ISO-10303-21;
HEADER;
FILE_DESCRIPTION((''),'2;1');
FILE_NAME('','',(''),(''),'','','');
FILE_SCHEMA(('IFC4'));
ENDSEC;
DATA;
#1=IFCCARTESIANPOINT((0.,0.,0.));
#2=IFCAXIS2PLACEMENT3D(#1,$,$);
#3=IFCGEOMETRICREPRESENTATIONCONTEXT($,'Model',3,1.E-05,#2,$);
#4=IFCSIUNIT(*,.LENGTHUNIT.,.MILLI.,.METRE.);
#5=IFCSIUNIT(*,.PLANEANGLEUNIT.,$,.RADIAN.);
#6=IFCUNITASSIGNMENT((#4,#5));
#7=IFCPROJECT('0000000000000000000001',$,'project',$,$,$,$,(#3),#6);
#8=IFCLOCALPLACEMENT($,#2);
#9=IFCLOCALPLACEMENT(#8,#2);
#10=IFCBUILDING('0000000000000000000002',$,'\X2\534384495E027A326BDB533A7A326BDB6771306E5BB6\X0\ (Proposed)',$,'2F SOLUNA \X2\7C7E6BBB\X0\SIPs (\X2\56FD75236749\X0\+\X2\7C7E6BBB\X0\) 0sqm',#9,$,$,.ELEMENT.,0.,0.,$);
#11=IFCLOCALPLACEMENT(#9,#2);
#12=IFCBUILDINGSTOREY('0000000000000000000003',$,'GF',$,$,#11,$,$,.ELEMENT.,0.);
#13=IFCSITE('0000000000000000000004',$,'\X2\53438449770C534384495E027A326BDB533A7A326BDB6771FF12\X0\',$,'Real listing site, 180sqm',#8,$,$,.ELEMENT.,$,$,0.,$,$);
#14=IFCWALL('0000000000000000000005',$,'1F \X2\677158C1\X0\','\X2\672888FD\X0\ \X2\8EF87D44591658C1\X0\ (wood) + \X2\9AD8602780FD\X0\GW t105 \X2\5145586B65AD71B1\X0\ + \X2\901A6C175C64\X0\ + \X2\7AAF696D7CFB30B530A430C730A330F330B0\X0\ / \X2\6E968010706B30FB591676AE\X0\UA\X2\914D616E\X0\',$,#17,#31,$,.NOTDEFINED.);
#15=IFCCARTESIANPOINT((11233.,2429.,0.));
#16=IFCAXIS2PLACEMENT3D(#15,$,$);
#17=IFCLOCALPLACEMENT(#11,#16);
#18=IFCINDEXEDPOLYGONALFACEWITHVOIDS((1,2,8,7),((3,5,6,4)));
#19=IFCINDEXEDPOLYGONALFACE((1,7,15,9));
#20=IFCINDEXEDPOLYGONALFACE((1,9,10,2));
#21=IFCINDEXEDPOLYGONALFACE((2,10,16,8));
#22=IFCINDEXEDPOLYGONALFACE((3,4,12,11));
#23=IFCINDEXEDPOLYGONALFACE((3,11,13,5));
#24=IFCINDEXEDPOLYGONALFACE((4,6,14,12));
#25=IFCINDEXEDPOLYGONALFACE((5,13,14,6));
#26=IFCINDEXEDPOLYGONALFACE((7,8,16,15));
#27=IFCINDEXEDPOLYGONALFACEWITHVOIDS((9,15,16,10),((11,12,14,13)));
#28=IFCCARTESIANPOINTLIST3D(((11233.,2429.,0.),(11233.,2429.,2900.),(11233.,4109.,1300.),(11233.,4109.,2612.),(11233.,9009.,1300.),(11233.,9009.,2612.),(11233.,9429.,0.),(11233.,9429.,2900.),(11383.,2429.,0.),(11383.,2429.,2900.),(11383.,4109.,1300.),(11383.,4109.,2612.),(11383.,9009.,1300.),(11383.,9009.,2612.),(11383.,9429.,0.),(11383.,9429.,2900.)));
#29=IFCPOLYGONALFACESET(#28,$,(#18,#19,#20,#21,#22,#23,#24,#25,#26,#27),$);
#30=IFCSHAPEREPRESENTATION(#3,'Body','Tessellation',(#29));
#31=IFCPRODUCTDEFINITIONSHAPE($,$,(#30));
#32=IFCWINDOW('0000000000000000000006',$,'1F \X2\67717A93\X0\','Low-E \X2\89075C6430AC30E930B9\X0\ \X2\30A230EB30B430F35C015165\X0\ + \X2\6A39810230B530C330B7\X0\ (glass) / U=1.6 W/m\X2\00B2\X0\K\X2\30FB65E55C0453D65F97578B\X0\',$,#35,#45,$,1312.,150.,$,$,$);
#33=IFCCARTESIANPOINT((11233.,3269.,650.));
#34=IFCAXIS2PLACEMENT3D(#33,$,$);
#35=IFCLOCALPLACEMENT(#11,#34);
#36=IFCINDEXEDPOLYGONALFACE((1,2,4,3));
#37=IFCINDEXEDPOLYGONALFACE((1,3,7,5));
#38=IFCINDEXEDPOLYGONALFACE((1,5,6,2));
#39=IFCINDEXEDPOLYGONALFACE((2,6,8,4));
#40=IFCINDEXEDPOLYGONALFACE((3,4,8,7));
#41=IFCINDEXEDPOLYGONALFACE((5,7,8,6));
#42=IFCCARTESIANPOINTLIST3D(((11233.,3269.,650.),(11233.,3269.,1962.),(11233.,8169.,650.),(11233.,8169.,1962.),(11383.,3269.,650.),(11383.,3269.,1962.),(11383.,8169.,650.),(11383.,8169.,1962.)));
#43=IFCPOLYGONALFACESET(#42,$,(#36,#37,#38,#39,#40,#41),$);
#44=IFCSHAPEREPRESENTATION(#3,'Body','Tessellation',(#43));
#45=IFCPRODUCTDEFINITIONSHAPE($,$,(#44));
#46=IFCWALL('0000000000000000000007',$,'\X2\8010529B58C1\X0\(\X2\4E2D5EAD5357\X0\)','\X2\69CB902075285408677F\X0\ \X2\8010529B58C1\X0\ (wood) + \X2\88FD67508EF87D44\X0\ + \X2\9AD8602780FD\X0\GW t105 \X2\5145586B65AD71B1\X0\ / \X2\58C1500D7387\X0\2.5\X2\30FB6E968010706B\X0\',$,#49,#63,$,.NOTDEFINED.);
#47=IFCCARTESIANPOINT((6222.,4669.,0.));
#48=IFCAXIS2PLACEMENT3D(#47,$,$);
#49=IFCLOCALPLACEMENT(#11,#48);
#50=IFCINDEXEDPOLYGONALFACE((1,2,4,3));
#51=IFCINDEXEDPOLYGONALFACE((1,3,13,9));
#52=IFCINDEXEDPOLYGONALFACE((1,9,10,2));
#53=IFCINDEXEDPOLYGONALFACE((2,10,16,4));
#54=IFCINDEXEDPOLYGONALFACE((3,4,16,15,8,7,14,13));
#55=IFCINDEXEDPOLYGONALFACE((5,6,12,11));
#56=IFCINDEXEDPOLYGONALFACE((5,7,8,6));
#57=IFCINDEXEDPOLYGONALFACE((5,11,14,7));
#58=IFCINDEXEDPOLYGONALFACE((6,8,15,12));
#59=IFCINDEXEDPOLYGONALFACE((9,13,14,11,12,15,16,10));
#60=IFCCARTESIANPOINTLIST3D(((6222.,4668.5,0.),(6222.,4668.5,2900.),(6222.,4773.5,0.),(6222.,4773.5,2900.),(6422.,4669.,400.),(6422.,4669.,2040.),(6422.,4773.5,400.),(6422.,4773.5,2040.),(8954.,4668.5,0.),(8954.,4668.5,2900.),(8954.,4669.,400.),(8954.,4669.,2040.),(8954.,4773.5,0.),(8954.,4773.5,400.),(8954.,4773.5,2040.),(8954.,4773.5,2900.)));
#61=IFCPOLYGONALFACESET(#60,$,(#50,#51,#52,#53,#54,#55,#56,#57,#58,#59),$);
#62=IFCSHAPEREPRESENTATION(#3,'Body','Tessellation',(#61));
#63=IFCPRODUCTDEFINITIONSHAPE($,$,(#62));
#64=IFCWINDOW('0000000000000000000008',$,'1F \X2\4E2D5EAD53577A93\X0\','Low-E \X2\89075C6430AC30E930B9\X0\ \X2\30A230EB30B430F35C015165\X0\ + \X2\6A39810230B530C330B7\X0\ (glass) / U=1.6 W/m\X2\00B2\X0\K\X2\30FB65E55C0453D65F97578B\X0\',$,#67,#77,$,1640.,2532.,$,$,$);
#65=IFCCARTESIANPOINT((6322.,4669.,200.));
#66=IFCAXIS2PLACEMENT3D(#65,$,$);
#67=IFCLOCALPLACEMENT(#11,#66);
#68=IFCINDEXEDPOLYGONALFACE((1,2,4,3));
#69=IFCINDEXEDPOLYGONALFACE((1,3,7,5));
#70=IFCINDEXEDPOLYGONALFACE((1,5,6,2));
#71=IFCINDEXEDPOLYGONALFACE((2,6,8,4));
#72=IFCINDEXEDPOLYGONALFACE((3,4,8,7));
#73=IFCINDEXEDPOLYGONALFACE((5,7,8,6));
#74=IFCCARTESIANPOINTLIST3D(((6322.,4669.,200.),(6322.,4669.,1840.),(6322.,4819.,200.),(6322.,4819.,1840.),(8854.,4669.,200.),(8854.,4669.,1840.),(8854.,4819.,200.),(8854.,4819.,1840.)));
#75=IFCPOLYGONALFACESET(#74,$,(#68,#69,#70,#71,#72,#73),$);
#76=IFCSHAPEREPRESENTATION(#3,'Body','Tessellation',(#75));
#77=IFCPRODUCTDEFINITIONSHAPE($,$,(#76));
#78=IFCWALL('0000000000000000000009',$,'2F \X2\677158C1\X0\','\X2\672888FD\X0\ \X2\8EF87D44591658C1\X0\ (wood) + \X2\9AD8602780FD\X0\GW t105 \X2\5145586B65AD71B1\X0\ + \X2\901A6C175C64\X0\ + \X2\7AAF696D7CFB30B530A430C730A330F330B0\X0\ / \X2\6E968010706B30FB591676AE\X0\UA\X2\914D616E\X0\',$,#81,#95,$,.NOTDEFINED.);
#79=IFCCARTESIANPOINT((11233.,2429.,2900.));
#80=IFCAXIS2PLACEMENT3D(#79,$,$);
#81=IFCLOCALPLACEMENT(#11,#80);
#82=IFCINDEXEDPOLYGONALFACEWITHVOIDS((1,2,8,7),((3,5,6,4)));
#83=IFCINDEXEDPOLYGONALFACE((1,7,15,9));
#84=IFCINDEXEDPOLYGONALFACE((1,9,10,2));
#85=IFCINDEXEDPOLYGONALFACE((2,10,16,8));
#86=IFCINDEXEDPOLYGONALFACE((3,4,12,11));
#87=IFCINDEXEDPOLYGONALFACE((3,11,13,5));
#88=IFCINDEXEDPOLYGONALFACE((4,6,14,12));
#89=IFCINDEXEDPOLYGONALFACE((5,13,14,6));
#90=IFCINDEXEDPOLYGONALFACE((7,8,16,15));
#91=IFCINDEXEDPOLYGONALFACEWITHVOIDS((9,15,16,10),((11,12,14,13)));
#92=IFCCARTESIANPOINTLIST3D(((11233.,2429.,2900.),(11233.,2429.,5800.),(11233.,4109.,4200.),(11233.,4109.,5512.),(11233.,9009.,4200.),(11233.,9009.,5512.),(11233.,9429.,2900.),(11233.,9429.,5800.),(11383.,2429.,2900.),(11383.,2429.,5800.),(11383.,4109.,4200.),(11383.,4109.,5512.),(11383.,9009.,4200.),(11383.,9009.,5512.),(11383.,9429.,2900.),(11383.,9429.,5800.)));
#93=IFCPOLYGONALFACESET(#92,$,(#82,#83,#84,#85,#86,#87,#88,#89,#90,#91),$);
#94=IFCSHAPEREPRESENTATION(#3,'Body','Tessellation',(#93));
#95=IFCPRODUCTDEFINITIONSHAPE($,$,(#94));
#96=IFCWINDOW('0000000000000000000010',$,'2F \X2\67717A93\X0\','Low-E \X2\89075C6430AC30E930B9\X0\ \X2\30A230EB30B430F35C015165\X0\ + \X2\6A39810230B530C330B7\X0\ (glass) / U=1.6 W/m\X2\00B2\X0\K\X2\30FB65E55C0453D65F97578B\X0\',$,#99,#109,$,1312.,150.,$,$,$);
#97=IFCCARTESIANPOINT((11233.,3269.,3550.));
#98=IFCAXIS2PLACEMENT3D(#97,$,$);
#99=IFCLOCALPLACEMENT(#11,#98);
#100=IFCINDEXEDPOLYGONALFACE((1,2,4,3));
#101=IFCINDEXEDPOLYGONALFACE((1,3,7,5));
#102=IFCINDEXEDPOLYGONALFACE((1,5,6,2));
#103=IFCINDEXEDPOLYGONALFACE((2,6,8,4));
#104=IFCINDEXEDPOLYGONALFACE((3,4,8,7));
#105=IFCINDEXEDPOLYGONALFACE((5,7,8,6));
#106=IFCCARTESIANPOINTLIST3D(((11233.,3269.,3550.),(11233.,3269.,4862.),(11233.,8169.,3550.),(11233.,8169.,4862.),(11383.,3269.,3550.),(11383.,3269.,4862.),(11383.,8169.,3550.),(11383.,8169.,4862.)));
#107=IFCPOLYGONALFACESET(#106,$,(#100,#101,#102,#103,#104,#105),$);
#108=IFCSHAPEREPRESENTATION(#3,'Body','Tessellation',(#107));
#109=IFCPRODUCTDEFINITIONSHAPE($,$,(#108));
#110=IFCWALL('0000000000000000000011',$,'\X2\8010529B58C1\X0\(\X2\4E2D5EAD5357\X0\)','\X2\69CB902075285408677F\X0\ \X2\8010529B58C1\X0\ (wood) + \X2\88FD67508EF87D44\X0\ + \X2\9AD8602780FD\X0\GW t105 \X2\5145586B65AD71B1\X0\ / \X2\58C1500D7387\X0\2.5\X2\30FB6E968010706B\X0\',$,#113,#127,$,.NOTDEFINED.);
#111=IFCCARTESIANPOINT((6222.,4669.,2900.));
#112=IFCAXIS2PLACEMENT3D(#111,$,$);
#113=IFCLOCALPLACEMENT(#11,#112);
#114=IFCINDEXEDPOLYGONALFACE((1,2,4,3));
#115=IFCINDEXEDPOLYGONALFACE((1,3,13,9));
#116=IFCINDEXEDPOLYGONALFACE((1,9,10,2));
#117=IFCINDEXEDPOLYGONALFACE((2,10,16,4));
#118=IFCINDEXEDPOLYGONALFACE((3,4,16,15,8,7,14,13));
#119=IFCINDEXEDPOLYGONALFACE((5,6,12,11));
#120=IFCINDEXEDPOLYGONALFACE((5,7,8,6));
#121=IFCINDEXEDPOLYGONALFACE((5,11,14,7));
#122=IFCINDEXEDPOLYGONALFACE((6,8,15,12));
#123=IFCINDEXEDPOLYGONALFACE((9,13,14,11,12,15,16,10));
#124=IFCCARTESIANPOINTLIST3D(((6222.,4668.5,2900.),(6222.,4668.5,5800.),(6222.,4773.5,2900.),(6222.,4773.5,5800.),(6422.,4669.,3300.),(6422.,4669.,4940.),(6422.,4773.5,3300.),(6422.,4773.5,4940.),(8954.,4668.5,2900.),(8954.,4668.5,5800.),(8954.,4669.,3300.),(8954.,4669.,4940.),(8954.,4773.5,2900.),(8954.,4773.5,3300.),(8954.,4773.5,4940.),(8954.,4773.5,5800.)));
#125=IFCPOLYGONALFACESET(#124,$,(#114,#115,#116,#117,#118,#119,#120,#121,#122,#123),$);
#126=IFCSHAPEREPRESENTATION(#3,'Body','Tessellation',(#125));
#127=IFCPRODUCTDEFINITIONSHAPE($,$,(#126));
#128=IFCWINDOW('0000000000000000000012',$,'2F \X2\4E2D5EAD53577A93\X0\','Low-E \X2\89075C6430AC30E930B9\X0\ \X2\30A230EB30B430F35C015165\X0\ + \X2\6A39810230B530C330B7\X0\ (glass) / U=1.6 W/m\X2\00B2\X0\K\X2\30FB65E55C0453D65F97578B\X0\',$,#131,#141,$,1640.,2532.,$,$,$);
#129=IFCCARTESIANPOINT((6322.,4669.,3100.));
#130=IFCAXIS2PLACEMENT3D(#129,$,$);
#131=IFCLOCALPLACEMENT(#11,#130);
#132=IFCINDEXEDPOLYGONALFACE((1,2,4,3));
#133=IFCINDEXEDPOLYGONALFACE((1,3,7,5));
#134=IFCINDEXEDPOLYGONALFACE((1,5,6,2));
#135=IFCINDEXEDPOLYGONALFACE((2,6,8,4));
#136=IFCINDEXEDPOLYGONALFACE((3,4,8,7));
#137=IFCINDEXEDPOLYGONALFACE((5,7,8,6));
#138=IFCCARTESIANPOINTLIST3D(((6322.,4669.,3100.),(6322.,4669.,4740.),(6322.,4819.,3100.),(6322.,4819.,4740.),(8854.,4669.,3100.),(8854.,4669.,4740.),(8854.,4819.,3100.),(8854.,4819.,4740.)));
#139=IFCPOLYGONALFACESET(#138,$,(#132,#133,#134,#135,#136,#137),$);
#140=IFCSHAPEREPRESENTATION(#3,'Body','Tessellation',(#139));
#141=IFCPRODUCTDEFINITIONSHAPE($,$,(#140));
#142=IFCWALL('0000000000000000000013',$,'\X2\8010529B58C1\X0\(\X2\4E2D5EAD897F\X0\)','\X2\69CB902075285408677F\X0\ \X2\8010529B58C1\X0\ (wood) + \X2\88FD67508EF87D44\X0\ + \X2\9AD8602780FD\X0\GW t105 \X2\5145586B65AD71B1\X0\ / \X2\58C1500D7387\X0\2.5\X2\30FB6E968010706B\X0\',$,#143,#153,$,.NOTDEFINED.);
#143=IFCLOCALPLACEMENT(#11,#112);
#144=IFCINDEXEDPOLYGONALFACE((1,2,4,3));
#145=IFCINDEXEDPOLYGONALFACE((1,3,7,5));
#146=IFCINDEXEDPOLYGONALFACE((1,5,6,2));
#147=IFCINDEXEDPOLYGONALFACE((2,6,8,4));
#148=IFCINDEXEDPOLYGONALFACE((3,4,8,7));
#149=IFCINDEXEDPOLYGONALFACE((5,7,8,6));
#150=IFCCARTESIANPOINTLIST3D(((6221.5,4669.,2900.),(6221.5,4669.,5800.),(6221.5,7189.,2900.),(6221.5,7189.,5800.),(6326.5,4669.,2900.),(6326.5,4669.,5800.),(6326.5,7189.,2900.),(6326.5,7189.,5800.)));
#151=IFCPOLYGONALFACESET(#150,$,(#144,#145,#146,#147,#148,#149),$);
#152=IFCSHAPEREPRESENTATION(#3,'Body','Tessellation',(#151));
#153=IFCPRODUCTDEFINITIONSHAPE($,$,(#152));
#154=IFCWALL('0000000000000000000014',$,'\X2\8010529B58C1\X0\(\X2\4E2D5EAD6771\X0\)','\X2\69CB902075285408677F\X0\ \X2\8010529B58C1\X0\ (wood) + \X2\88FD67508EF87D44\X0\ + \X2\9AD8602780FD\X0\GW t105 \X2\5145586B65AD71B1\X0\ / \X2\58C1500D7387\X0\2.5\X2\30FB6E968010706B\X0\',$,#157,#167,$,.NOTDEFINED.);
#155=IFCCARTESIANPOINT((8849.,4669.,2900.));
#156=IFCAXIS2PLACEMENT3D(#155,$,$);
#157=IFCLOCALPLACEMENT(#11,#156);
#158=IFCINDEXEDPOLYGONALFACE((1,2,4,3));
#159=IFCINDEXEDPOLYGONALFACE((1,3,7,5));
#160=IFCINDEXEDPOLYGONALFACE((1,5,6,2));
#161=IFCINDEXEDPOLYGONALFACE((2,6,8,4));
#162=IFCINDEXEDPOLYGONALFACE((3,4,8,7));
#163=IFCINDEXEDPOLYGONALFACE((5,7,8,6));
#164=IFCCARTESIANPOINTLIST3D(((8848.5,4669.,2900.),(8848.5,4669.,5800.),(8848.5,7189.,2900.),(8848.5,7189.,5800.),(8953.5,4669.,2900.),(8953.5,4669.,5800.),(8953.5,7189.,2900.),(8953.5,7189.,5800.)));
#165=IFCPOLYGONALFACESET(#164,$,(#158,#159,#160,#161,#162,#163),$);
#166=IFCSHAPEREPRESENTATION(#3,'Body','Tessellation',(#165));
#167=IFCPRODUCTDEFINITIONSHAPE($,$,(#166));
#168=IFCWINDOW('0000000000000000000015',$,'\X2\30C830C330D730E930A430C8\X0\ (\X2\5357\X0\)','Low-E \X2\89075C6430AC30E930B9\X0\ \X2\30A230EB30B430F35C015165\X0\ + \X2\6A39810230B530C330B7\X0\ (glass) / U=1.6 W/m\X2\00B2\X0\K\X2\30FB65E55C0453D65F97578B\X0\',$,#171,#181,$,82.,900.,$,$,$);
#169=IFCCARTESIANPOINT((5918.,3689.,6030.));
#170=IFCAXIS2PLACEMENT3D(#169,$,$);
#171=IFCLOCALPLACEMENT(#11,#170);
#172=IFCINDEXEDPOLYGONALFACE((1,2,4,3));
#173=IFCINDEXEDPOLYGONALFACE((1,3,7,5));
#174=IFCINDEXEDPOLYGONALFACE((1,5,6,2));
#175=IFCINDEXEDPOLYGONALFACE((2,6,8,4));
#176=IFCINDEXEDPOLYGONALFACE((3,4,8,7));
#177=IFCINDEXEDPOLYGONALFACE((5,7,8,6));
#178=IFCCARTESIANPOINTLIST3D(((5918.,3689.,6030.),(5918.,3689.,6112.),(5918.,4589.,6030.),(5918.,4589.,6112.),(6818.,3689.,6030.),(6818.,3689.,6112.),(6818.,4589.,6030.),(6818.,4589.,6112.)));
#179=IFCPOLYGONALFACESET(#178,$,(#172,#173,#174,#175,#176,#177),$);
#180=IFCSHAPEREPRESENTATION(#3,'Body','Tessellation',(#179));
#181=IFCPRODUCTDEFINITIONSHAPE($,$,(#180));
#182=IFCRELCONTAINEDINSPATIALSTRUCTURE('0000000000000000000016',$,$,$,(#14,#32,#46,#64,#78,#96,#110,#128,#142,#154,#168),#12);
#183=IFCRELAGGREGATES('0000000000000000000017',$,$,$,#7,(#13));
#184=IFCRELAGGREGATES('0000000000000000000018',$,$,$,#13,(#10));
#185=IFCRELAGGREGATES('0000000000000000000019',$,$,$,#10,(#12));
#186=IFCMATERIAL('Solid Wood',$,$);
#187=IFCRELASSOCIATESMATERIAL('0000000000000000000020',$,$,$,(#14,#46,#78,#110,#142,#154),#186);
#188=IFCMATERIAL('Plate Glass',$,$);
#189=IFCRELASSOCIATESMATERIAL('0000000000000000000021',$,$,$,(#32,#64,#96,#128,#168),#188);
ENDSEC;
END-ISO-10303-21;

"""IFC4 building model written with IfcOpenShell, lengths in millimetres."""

from ifc_helpers import new_model, si_unit, frame, frame_2d, origin, place, context, project, spatial, rectangle, extrude, material, element, fill, save


model = new_model("IFC4")

# Units and contexts
model_context = context("Model", 3, precision=1e-05, world=origin())
ifc_project = project(units=[si_unit("LENGTHUNIT", "METRE", prefix="MILLI"), si_unit("PLANEANGLEUNIT", "RADIAN")], contexts=[model_context])

# Site, building, storey
site_placement = place(None, origin())
site = spatial("IfcSite", under=ifc_project, at=site_placement, Name="千葉県千葉市稲毛区稲毛東２", ObjectType="Real listing site, 180sqm", CompositionType="ELEMENT", RefElevation=0.0)
building_placement = place(site_placement, origin())
building = spatial("IfcBuilding", under=site, at=building_placement, Name="千葉市稲毛区稲毛東の家 (Proposed)", ObjectType="2F SOLUNA 籾殻SIPs (国産杉+籾殻) 0sqm", CompositionType="ELEMENT", ElevationOfRefHeight=0.0, ElevationOfTerrain=0.0)
storey_placement = place(building_placement, origin())
storey = spatial("IfcBuildingStorey", under=building, at=storey_placement, Name="GF", CompositionType="ELEMENT", Elevation=0.0)

# Shared definitions
ifc_material_1 = material(Name="Solid Wood")

# Walls, openings, windows
wall_1_placement = place(storey_placement, frame((11233.0, 2429.0, 0.0)))
wall_1 = element("IfcWall", 1, at=wall_1_placement, inside=storey, material=ifc_material_1, Name="1F 東壁", Description="木製 軸組外壁 (wood) + 高性能GW t105 充填断熱 + 通気層 + 窯業系サイディング / 準耐火・外皮UA配慮", PredefinedType="NOTDEFINED", context=model_context, shape_type="SweptSolid", body=[
    extrude(rectangle(XDim=150.0, YDim=7000.0, at=frame_2d((75.0, 3500.0))), frame((11233.0, 2429.0, 0.0)), (0.0, 0.0, 1.0), 2900.0),
])
opening_1_placement = place(storey_placement, frame((11233.0, 3269.0, 650.0)))
opening_1 = element("IfcOpeningElement", 2, at=opening_1_placement, cuts=wall_1, PredefinedType="NOTDEFINED", context=model_context, shape_type="SweptSolid", body=[
    extrude(rectangle(XDim=150.0, YDim=4900.0, at=frame_2d((75.0, 2450.0))), frame((11233.0, 3269.0, 650.0)), (0.0, 0.0, 1.0), 1312.0),
])
ifc_material_2 = material(Name="Plate Glass")
window_1_placement = place(storey_placement, frame((11233.0, 3269.0, 650.0)))
window_1 = element("IfcWindow", 3, at=window_1_placement, inside=storey, material=ifc_material_2, Name="1F 東窓", Description="Low-E 複層ガラス アルゴン封入 + 樹脂サッシ (glass) / U=1.6 W/m²K・日射取得型", OverallHeight=1312.0, OverallWidth=150.0, context=model_context, shape_type="SweptSolid", body=[
    extrude(rectangle(XDim=150.0, YDim=4900.0, at=frame_2d((75.0, 2450.0))), frame((11233.0, 3269.0, 650.0)), (0.0, 0.0, 1.0), 1312.0),
])
fill(opening_1, window_1)
wall_2_placement = place(storey_placement, frame((6222.0, 4669.0, 0.0)))
wall_2 = element("IfcWall", 4, at=wall_2_placement, inside=storey, material=ifc_material_1, Name="耐力壁(中庭南)", Description="構造用合板 耐力壁 (wood) + 製材軸組 + 高性能GW t105 充填断熱 / 壁倍率2.5・準耐火", PredefinedType="NOTDEFINED", context=model_context, shape_type="SweptSolid", body=[
    extrude(rectangle(XDim=2732.0, YDim=105.0, at=frame_2d((1366.0, 52.0))), frame((6222.0, 4669.0, 0.0)), (0.0, 0.0, 1.0), 2900.0),
])
opening_2_placement = place(storey_placement, frame((6322.0, 4669.0, 200.0)))
opening_2 = element("IfcOpeningElement", 5, at=opening_2_placement, cuts=wall_2, PredefinedType="NOTDEFINED", context=model_context, shape_type="SweptSolid", body=[
    extrude(rectangle(XDim=2532.0, YDim=150.0, at=frame_2d((1266.0, 75.0))), frame((6322.0, 4669.0, 200.0)), (0.0, 0.0, 1.0), 1640.0),
])
window_2_placement = place(storey_placement, frame((6322.0, 4669.0, 200.0)))
window_2 = element("IfcWindow", 6, at=window_2_placement, inside=storey, material=ifc_material_2, Name="1F 中庭南窓", Description="Low-E 複層ガラス アルゴン封入 + 樹脂サッシ (glass) / U=1.6 W/m²K・日射取得型", OverallHeight=1640.0, OverallWidth=2532.0, context=model_context, shape_type="SweptSolid", body=[
    extrude(rectangle(XDim=2532.0, YDim=150.0, at=frame_2d((1266.0, 75.0))), frame((6322.0, 4669.0, 200.0)), (0.0, 0.0, 1.0), 1640.0),
])
fill(opening_2, window_2)

# Walls, openings, windows
wall_3_placement = place(storey_placement, frame((11233.0, 2429.0, 2900.0)))
wall_3 = element("IfcWall", 7, at=wall_3_placement, inside=storey, material=ifc_material_1, Name="2F 東壁", Description="木製 軸組外壁 (wood) + 高性能GW t105 充填断熱 + 通気層 + 窯業系サイディング / 準耐火・外皮UA配慮", PredefinedType="NOTDEFINED", context=model_context, shape_type="SweptSolid", body=[
    extrude(rectangle(XDim=150.0, YDim=7000.0, at=frame_2d((75.0, 3500.0))), frame((11233.0, 2429.0, 2900.0)), (0.0, 0.0, 1.0), 2900.0),
])
opening_3_placement = place(storey_placement, frame((11233.0, 3269.0, 3550.0)))
opening_3 = element("IfcOpeningElement", 8, at=opening_3_placement, cuts=wall_3, PredefinedType="NOTDEFINED", context=model_context, shape_type="SweptSolid", body=[
    extrude(rectangle(XDim=150.0, YDim=4900.0, at=frame_2d((75.0, 2450.0))), frame((11233.0, 3269.0, 3550.0)), (0.0, 0.0, 1.0), 1312.0),
])
window_3_placement = place(storey_placement, frame((11233.0, 3269.0, 3550.0)))
window_3 = element("IfcWindow", 9, at=window_3_placement, inside=storey, material=ifc_material_2, Name="2F 東窓", Description="Low-E 複層ガラス アルゴン封入 + 樹脂サッシ (glass) / U=1.6 W/m²K・日射取得型", OverallHeight=1312.0, OverallWidth=150.0, context=model_context, shape_type="SweptSolid", body=[
    extrude(rectangle(XDim=150.0, YDim=4900.0, at=frame_2d((75.0, 2450.0))), frame((11233.0, 3269.0, 3550.0)), (0.0, 0.0, 1.0), 1312.0),
])
fill(opening_3, window_3)
wall_4_placement = place(storey_placement, frame((6222.0, 4669.0, 2900.0)))
wall_4 = element("IfcWall", 10, at=wall_4_placement, inside=storey, material=ifc_material_1, Name="耐力壁(中庭南)", Description="構造用合板 耐力壁 (wood) + 製材軸組 + 高性能GW t105 充填断熱 / 壁倍率2.5・準耐火", PredefinedType="NOTDEFINED", context=model_context, shape_type="SweptSolid", body=[
    extrude(rectangle(XDim=2732.0, YDim=105.0, at=frame_2d((1366.0, 52.0))), frame((6222.0, 4669.0, 2900.0)), (0.0, 0.0, 1.0), 2900.0),
])
opening_4_placement = place(storey_placement, frame((6322.0, 4669.0, 3100.0)))
opening_4 = element("IfcOpeningElement", 11, at=opening_4_placement, cuts=wall_4, PredefinedType="NOTDEFINED", context=model_context, shape_type="SweptSolid", body=[
    extrude(rectangle(XDim=2532.0, YDim=150.0, at=frame_2d((1266.0, 75.0))), frame((6322.0, 4669.0, 3100.0)), (0.0, 0.0, 1.0), 1640.0),
])
window_4_placement = place(storey_placement, frame((6322.0, 4669.0, 3100.0)))
window_4 = element("IfcWindow", 12, at=window_4_placement, inside=storey, material=ifc_material_2, Name="2F 中庭南窓", Description="Low-E 複層ガラス アルゴン封入 + 樹脂サッシ (glass) / U=1.6 W/m²K・日射取得型", OverallHeight=1640.0, OverallWidth=2532.0, context=model_context, shape_type="SweptSolid", body=[
    extrude(rectangle(XDim=2532.0, YDim=150.0, at=frame_2d((1266.0, 75.0))), frame((6322.0, 4669.0, 3100.0)), (0.0, 0.0, 1.0), 1640.0),
])
fill(opening_4, window_4)

# Walls
wall_5_placement = place(storey_placement, frame((6222.0, 4669.0, 2900.0)))
element("IfcWall", 13, at=wall_5_placement, inside=storey, material=ifc_material_1, Name="耐力壁(中庭西)", Description="構造用合板 耐力壁 (wood) + 製材軸組 + 高性能GW t105 充填断熱 / 壁倍率2.5・準耐火", PredefinedType="NOTDEFINED", context=model_context, shape_type="SweptSolid", body=[
    extrude(rectangle(XDim=105.0, YDim=2520.0, at=frame_2d((52.0, 1260.0))), frame((6222.0, 4669.0, 2900.0)), (0.0, 0.0, 1.0), 2900.0),
])
wall_6_placement = place(storey_placement, frame((8849.0, 4669.0, 2900.0)))
element("IfcWall", 14, at=wall_6_placement, inside=storey, material=ifc_material_1, Name="耐力壁(中庭東)", Description="構造用合板 耐力壁 (wood) + 製材軸組 + 高性能GW t105 充填断熱 / 壁倍率2.5・準耐火", PredefinedType="NOTDEFINED", context=model_context, shape_type="SweptSolid", body=[
    extrude(rectangle(XDim=105.0, YDim=2520.0, at=frame_2d((52.0, 1260.0))), frame((8849.0, 4669.0, 2900.0)), (0.0, 0.0, 1.0), 2900.0),
])

# Window
window_5_placement = place(storey_placement, frame((5918.0, 3689.0, 6030.0)))
element("IfcWindow", 15, at=window_5_placement, inside=storey, material=ifc_material_2, Name="トップライト (南)", Description="Low-E 複層ガラス アルゴン封入 + 樹脂サッシ (glass) / U=1.6 W/m²K・日射取得型", OverallHeight=82.0, OverallWidth=900.0, context=model_context, shape_type="SweptSolid", body=[
    extrude(rectangle(XDim=900.0, YDim=900.0, at=frame_2d((450.0, 450.0))), frame((5918.0, 3689.0, 6030.0)), (0.0, 0.0, 1.0), 82.0),
])

save(model, "model.ifc")
